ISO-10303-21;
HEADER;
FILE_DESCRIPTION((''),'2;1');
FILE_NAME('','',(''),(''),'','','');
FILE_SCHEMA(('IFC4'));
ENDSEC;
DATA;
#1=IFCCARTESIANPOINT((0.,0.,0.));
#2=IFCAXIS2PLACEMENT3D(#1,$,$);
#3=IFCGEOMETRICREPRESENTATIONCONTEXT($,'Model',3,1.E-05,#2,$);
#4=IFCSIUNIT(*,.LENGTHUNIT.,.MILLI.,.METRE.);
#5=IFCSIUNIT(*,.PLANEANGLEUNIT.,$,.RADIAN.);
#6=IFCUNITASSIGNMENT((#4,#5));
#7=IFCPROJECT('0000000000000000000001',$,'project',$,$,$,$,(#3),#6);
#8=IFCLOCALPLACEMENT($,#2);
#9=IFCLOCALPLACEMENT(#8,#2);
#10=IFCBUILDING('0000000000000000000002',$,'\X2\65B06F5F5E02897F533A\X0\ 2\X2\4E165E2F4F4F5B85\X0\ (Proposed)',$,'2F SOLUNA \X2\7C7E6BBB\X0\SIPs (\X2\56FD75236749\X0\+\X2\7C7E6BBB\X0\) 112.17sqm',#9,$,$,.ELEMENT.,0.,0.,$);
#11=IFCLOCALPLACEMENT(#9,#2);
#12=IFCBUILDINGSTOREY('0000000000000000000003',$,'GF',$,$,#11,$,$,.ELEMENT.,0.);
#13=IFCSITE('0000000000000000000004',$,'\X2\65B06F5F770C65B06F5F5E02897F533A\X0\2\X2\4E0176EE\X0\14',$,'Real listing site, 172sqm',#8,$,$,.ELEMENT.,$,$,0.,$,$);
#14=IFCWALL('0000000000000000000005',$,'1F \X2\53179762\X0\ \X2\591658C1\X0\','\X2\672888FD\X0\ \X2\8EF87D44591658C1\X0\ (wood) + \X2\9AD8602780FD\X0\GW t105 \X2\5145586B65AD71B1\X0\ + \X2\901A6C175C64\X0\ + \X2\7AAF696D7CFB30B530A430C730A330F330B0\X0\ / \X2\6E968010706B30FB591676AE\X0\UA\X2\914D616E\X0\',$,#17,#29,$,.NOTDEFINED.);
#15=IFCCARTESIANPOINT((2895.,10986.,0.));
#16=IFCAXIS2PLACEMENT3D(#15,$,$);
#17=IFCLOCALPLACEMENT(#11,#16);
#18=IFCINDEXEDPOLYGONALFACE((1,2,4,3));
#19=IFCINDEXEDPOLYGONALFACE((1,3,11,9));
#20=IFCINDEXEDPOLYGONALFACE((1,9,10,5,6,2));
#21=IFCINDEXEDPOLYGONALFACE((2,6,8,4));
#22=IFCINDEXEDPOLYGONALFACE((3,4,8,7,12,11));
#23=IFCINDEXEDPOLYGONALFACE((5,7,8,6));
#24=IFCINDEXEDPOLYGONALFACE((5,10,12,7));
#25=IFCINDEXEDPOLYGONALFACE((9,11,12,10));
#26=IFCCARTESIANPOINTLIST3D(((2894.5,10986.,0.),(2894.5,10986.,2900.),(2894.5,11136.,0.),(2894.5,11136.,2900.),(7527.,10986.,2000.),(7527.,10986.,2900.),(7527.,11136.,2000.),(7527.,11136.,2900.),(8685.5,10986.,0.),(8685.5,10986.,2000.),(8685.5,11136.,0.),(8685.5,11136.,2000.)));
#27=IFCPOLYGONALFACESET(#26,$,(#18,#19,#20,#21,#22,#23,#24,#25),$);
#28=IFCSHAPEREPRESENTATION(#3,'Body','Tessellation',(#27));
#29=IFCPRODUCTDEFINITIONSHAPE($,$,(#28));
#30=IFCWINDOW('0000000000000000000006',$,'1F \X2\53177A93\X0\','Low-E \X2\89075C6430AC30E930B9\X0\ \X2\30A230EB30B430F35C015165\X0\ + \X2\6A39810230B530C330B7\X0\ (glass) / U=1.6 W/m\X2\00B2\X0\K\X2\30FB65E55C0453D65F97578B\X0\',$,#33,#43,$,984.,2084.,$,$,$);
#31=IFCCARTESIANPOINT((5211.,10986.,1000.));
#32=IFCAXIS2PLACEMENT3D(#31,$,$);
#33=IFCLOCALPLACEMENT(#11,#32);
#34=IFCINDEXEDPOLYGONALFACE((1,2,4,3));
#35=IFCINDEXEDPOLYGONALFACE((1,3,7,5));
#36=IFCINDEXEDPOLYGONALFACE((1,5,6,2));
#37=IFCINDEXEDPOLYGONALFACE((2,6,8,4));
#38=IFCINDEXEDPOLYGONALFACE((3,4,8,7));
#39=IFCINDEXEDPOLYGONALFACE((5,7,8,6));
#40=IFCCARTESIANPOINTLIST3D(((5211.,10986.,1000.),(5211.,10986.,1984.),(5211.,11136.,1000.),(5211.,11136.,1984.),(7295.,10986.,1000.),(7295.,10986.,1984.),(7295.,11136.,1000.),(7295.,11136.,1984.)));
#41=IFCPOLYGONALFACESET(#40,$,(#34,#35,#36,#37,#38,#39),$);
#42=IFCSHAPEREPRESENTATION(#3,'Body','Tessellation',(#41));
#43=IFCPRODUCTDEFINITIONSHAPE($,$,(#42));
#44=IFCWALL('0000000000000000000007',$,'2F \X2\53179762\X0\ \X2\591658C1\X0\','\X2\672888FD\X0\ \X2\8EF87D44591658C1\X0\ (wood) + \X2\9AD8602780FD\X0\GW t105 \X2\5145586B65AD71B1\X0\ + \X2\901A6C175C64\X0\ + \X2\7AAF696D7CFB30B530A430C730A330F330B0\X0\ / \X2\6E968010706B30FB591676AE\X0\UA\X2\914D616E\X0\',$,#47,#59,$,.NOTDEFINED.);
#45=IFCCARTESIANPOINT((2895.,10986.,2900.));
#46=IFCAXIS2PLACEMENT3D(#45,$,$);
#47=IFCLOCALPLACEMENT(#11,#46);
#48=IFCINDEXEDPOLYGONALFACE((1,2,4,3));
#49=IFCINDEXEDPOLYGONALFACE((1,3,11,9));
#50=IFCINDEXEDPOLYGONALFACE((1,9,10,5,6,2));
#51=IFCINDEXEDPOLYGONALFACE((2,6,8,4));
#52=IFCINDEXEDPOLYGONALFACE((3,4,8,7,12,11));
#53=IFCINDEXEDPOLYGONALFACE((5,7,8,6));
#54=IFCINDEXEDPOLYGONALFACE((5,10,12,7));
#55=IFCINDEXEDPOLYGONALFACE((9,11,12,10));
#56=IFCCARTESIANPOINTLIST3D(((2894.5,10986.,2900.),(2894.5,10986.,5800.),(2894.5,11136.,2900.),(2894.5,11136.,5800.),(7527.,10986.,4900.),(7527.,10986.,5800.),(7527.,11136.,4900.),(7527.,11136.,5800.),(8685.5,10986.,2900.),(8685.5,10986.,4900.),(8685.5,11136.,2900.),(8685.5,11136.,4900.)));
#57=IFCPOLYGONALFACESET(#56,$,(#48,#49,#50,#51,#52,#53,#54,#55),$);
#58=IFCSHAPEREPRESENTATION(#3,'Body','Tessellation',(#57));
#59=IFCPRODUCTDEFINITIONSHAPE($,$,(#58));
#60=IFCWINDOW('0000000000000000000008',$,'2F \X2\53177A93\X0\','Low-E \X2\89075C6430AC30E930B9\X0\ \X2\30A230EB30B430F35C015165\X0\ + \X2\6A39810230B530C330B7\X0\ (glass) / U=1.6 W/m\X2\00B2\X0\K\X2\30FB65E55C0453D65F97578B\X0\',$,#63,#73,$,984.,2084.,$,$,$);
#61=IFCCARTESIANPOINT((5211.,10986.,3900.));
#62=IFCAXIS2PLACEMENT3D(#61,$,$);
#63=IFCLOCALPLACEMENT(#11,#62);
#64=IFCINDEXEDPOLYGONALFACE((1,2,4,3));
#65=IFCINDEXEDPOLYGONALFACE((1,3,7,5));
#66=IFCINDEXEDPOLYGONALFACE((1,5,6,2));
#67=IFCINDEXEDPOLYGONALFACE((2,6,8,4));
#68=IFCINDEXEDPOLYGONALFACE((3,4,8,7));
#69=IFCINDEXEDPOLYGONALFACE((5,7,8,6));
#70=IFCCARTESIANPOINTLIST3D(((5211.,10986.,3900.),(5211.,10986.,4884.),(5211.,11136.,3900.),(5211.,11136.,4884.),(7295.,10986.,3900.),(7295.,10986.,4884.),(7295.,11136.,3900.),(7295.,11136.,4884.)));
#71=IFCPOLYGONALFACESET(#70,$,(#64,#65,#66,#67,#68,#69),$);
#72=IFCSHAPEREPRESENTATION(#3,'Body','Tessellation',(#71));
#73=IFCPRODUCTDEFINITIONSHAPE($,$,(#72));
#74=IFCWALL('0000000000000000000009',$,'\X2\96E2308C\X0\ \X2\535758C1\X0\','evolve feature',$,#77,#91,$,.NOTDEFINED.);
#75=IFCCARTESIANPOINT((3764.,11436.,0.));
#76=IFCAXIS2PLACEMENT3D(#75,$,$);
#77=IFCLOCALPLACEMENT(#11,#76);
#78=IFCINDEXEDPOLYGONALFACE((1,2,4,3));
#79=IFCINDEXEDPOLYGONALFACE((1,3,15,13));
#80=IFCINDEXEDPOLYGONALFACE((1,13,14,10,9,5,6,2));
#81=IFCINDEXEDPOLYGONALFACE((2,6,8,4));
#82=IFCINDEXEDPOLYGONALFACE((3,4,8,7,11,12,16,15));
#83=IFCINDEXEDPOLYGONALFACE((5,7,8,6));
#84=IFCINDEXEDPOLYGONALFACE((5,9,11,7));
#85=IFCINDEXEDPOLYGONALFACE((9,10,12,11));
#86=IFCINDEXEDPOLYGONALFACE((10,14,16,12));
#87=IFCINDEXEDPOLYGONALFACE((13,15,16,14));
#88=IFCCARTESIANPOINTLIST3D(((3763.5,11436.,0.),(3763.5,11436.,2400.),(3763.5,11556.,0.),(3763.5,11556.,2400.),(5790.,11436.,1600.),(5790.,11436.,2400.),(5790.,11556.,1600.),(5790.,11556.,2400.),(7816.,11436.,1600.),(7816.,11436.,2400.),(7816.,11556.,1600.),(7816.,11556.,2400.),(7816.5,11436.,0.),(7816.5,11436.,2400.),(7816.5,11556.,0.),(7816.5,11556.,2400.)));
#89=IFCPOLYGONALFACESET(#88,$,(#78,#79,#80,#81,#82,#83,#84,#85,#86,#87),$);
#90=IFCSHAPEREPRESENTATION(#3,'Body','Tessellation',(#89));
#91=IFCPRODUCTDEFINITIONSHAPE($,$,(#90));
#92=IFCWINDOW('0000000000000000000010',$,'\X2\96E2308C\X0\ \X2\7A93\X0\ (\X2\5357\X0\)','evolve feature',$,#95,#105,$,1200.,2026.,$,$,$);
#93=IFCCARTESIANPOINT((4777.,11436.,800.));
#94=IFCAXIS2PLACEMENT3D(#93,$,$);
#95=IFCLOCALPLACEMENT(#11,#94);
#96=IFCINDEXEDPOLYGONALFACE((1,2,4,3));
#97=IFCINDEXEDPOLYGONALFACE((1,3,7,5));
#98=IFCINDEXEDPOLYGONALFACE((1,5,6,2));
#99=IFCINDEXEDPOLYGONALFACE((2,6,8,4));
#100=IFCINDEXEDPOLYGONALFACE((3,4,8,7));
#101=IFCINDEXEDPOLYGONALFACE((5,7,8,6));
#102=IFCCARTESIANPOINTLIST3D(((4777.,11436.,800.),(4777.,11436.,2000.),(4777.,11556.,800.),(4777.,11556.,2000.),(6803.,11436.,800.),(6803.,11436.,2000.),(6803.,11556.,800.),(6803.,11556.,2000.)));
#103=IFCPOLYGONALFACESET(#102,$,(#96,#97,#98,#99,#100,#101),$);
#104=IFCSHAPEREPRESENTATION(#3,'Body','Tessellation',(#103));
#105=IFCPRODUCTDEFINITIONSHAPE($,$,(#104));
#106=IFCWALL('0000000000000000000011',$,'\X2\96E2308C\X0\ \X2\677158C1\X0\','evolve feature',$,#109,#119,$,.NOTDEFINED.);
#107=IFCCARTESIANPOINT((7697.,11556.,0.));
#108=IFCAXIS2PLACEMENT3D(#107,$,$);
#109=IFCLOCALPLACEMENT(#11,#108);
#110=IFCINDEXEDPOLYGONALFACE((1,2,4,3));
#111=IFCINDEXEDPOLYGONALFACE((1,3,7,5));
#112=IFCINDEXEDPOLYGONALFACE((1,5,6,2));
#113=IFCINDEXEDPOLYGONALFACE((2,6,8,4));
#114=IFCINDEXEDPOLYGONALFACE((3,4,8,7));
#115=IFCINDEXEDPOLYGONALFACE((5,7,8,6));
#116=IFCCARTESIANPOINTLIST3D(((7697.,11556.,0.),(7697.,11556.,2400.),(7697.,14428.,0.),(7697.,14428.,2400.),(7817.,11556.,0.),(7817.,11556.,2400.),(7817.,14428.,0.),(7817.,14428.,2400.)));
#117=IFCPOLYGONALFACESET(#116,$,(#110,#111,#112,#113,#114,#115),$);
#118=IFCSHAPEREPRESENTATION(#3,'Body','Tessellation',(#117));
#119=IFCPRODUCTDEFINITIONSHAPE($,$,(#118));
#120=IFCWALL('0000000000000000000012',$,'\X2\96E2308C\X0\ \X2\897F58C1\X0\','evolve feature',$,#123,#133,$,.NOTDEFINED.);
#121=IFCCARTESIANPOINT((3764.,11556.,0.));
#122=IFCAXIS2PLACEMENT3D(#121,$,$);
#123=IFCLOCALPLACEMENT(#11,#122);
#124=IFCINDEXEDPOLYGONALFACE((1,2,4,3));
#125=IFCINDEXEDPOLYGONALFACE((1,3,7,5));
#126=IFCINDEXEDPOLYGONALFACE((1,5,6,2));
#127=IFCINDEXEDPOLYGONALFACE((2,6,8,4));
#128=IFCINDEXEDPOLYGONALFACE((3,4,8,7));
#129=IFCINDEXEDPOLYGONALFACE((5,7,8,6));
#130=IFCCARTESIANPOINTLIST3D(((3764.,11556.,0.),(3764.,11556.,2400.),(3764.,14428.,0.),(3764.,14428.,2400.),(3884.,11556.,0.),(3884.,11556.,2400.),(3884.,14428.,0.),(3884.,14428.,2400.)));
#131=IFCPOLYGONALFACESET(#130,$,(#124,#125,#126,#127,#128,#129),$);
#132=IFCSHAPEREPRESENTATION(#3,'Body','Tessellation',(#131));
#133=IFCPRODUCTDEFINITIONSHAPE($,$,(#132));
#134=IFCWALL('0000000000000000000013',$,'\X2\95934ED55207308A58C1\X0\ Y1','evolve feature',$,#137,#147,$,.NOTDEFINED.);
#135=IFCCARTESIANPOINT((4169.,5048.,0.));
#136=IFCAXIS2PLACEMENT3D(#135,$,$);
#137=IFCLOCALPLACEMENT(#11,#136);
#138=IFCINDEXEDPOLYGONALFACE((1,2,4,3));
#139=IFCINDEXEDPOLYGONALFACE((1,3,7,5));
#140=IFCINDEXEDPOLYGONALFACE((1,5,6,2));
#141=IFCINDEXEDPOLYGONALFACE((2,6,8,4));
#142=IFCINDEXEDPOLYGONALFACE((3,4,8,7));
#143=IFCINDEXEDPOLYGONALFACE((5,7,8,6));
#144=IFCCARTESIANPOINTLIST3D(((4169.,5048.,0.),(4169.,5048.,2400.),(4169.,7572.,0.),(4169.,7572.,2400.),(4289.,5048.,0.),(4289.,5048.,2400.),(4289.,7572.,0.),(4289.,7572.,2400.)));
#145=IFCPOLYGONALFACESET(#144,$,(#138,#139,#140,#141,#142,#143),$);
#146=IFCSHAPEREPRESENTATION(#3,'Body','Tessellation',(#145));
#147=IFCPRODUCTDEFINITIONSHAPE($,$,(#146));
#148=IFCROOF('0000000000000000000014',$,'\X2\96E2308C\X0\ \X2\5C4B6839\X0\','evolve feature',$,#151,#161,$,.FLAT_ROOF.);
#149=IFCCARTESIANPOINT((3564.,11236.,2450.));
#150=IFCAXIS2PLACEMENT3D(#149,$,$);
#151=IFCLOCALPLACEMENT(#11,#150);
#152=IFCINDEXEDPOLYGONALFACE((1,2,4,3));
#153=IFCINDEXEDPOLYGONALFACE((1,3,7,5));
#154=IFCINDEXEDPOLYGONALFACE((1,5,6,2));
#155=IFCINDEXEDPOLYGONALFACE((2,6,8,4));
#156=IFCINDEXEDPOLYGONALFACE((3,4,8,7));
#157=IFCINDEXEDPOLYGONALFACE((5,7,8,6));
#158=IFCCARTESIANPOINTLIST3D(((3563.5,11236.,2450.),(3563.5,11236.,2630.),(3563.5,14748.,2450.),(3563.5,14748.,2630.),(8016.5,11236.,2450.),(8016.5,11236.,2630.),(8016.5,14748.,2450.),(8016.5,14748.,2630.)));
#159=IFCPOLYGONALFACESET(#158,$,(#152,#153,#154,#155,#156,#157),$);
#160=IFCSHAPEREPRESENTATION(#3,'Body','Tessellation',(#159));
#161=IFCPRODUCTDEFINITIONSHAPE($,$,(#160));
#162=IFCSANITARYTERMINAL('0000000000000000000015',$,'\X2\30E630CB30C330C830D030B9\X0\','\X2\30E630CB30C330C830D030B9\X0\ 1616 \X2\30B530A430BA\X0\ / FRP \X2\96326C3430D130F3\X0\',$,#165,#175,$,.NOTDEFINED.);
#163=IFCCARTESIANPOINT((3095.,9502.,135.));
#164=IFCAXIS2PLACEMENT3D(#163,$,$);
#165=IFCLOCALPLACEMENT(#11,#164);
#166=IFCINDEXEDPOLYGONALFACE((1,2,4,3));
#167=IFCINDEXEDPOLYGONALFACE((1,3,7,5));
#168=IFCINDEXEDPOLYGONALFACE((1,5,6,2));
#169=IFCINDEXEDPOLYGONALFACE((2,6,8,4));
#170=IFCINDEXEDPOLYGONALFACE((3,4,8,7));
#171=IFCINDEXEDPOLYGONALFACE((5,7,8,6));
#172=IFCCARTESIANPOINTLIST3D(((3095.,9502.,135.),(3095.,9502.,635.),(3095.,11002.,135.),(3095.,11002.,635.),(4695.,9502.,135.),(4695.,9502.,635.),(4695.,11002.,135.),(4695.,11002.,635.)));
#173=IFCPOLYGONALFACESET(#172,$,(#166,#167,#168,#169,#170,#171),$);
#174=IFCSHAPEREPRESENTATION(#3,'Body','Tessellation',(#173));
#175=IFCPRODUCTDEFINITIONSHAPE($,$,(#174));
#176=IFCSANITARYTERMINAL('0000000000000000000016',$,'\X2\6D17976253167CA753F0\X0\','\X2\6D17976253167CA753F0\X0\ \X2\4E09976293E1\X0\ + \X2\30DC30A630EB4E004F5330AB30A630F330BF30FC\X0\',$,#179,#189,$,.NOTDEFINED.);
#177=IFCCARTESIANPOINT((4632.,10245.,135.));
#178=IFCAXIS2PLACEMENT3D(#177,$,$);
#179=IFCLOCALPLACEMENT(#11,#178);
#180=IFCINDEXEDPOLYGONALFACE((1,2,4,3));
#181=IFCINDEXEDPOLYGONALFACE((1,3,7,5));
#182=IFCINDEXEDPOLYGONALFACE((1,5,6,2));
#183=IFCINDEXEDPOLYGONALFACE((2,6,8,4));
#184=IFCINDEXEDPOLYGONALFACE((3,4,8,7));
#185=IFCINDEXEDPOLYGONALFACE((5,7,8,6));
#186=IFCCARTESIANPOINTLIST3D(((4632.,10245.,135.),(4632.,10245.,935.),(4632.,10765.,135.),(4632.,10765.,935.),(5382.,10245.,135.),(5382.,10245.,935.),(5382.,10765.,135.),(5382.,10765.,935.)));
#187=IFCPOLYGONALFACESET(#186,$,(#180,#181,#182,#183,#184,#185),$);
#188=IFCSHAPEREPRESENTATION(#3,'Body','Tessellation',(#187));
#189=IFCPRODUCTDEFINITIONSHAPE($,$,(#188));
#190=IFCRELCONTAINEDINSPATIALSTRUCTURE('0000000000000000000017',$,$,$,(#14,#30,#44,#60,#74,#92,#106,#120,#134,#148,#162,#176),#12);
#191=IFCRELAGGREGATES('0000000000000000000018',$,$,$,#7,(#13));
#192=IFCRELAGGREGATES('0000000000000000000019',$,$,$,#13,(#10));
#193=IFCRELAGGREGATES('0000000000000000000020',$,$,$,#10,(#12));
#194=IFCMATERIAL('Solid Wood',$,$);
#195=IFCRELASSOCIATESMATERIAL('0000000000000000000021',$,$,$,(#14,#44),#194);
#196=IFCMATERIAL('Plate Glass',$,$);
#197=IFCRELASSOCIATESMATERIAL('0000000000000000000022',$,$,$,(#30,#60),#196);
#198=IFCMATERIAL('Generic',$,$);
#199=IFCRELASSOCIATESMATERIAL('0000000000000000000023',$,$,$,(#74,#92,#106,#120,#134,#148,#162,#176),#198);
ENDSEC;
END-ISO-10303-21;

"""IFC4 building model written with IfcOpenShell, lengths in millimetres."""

from ifc_helpers import new_model, si_unit, frame, frame_2d, origin, place, context, project, spatial, rectangle, extrude, material, element, fill, save


model = new_model("IFC4")

# Units and contexts
model_context = context("Model", 3, precision=1e-05, world=origin())
ifc_project = project(units=[si_unit("LENGTHUNIT", "METRE", prefix="MILLI"), si_unit("PLANEANGLEUNIT", "RADIAN")], contexts=[model_context])

# Site, building, storey
site_placement = place(None, origin())
site = spatial("IfcSite", under=ifc_project, at=site_placement, Name="新潟県新潟市西区2丁目14", ObjectType="Real listing site, 172sqm", CompositionType="ELEMENT", RefElevation=0.0)
building_placement = place(site_placement, origin())
building = spatial("IfcBuilding", under=site, at=building_placement, Name="新潟市西区 2世帯住宅 (Proposed)", ObjectType="2F SOLUNA 籾殻SIPs (国産杉+籾殻) 112.17sqm", CompositionType="ELEMENT", ElevationOfRefHeight=0.0, ElevationOfTerrain=0.0)
storey_placement = place(building_placement, origin())
storey = spatial("IfcBuildingStorey", under=building, at=storey_placement, Name="GF", CompositionType="ELEMENT", Elevation=0.0)

# Shared definitions
ifc_material_1 = material(Name="Generic")

# Wall, opening, window
ifc_material_2 = material(Name="Solid Wood")
wall_1_placement = place(storey_placement, frame((2895.0, 10986.0, 0.0)))
wall_1 = element("IfcWall", 1, at=wall_1_placement, inside=storey, material=ifc_material_2, Name="1F 北面 外壁", Description="木製 軸組外壁 (wood) + 高性能GW t105 充填断熱 + 通気層 + 窯業系サイディング / 準耐火・外皮UA配慮", PredefinedType="NOTDEFINED", context=model_context, shape_type="SweptSolid", body=[
    extrude(rectangle(XDim=5791.0, YDim=150.0, at=frame_2d((2895.0, 75.0))), frame((2895.0, 10986.0, 0.0)), (0.0, 0.0, 1.0), 2900.0),
])
opening_1_placement = place(storey_placement, frame((5211.0, 10986.0, 1000.0)))
opening_1 = element("IfcOpeningElement", 2, at=opening_1_placement, cuts=wall_1, PredefinedType="NOTDEFINED", context=model_context, shape_type="SweptSolid", body=[
    extrude(rectangle(XDim=2084.0, YDim=150.0, at=frame_2d((1042.0, 75.0))), frame((5211.0, 10986.0, 1000.0)), (0.0, 0.0, 1.0), 984.0),
])
ifc_material_3 = material(Name="Plate Glass")
window_1_placement = place(storey_placement, frame((5211.0, 10986.0, 1000.0)))
window_1 = element("IfcWindow", 3, at=window_1_placement, inside=storey, material=ifc_material_3, Name="1F 北窓", Description="Low-E 複層ガラス アルゴン封入 + 樹脂サッシ (glass) / U=1.6 W/m²K・日射取得型", OverallHeight=984.0, OverallWidth=2084.0, context=model_context, shape_type="SweptSolid", body=[
    extrude(rectangle(XDim=2084.0, YDim=150.0, at=frame_2d((1042.0, 75.0))), frame((5211.0, 10986.0, 1000.0)), (0.0, 0.0, 1.0), 984.0),
])
fill(opening_1, window_1)

# Wall, opening, window
wall_2_placement = place(storey_placement, frame((2895.0, 10986.0, 2900.0)))
wall_2 = element("IfcWall", 4, at=wall_2_placement, inside=storey, material=ifc_material_2, Name="2F 北面 外壁", Description="木製 軸組外壁 (wood) + 高性能GW t105 充填断熱 + 通気層 + 窯業系サイディング / 準耐火・外皮UA配慮", PredefinedType="NOTDEFINED", context=model_context, shape_type="SweptSolid", body=[
    extrude(rectangle(XDim=5791.0, YDim=150.0, at=frame_2d((2895.0, 75.0))), frame((2895.0, 10986.0, 2900.0)), (0.0, 0.0, 1.0), 2900.0),
])
opening_2_placement = place(storey_placement, frame((5211.0, 10986.0, 3900.0)))
opening_2 = element("IfcOpeningElement", 5, at=opening_2_placement, cuts=wall_2, PredefinedType="NOTDEFINED", context=model_context, shape_type="SweptSolid", body=[
    extrude(rectangle(XDim=2084.0, YDim=150.0, at=frame_2d((1042.0, 75.0))), frame((5211.0, 10986.0, 3900.0)), (0.0, 0.0, 1.0), 984.0),
])
window_2_placement = place(storey_placement, frame((5211.0, 10986.0, 3900.0)))
window_2 = element("IfcWindow", 6, at=window_2_placement, inside=storey, material=ifc_material_3, Name="2F 北窓", Description="Low-E 複層ガラス アルゴン封入 + 樹脂サッシ (glass) / U=1.6 W/m²K・日射取得型", OverallHeight=984.0, OverallWidth=2084.0, context=model_context, shape_type="SweptSolid", body=[
    extrude(rectangle(XDim=2084.0, YDim=150.0, at=frame_2d((1042.0, 75.0))), frame((5211.0, 10986.0, 3900.0)), (0.0, 0.0, 1.0), 984.0),
])
fill(opening_2, window_2)

# Wall, opening, window
wall_3_placement = place(storey_placement, frame((3764.0, 11436.0, 0.0)))
wall_3 = element("IfcWall", 7, at=wall_3_placement, inside=storey, material=ifc_material_1, Name="離れ 南壁", Description="evolve feature", PredefinedType="NOTDEFINED", context=model_context, shape_type="SweptSolid", body=[
    extrude(rectangle(XDim=4053.0, YDim=120.0, at=frame_2d((2026.0, 60.0))), frame((3764.0, 11436.0, 0.0)), (0.0, 0.0, 1.0), 2400.0),
])
opening_3_placement = place(storey_placement, frame((4777.0, 11436.0, 800.0)))
opening_3 = element("IfcOpeningElement", 8, at=opening_3_placement, cuts=wall_3, PredefinedType="NOTDEFINED", context=model_context, shape_type="SweptSolid", body=[
    extrude(rectangle(XDim=2026.0, YDim=120.0, at=frame_2d((1013.0, 60.0))), frame((4777.0, 11436.0, 800.0)), (0.0, 0.0, 1.0), 1200.0),
])
window_3_placement = place(storey_placement, frame((4777.0, 11436.0, 800.0)))
window_3 = element("IfcWindow", 9, at=window_3_placement, inside=storey, material=ifc_material_1, Name="離れ 窓 (南)", Description="evolve feature", OverallHeight=1200.0, OverallWidth=2026.0, context=model_context, shape_type="SweptSolid", body=[
    extrude(rectangle(XDim=2026.0, YDim=120.0, at=frame_2d((1013.0, 60.0))), frame((4777.0, 11436.0, 800.0)), (0.0, 0.0, 1.0), 1200.0),
])
fill(opening_3, window_3)

# Walls
wall_4_placement = place(storey_placement, frame((7697.0, 11556.0, 0.0)))
element("IfcWall", 10, at=wall_4_placement, inside=storey, material=ifc_material_1, Name="離れ 東壁", Description="evolve feature", PredefinedType="NOTDEFINED", context=model_context, shape_type="SweptSolid", body=[
    extrude(rectangle(XDim=120.0, YDim=2872.0, at=frame_2d((60.0, 1436.0))), frame((7697.0, 11556.0, 0.0)), (0.0, 0.0, 1.0), 2400.0),
])
wall_5_placement = place(storey_placement, frame((3764.0, 11556.0, 0.0)))
element("IfcWall", 11, at=wall_5_placement, inside=storey, material=ifc_material_1, Name="離れ 西壁", Description="evolve feature", PredefinedType="NOTDEFINED", context=model_context, shape_type="SweptSolid", body=[
    extrude(rectangle(XDim=120.0, YDim=2872.0, at=frame_2d((60.0, 1436.0))), frame((3764.0, 11556.0, 0.0)), (0.0, 0.0, 1.0), 2400.0),
])
wall_6_placement = place(storey_placement, frame((4169.0, 5048.0, 0.0)))
element("IfcWall", 12, at=wall_6_placement, inside=storey, material=ifc_material_1, Name="間仕切り壁 Y1", Description="evolve feature", PredefinedType="NOTDEFINED", context=model_context, shape_type="SweptSolid", body=[
    extrude(rectangle(XDim=120.0, YDim=2524.0, at=frame_2d((60.0, 1262.0))), frame((4169.0, 5048.0, 0.0)), (0.0, 0.0, 1.0), 2400.0),
])

# Roof
roof_1_placement = place(storey_placement, frame((3564.0, 11236.0, 2450.0)))
element("IfcRoof", 13, at=roof_1_placement, inside=storey, material=ifc_material_1, Name="離れ 屋根", Description="evolve feature", PredefinedType="FLAT_ROOF", context=model_context, shape_type="SweptSolid", body=[
    extrude(rectangle(XDim=4453.0, YDim=3512.0, at=frame_2d((2226.0, 1756.0))), frame((3564.0, 11236.0, 2450.0)), (0.0, 0.0, 1.0), 180.0),
])

# Sanitary terminals
sanitary_terminal_1_placement = place(storey_placement, frame((3095.0, 9502.0, 135.0)))
element("IfcSanitaryTerminal", 14, at=sanitary_terminal_1_placement, inside=storey, material=ifc_material_1, Name="ユニットバス", Description="ユニットバス 1616 サイズ / FRP 防水パン", PredefinedType="NOTDEFINED", context=model_context, shape_type="SweptSolid", body=[
    extrude(rectangle(XDim=1600.0, YDim=1500.0, at=frame_2d((800.0, 750.0))), frame((3095.0, 9502.0, 135.0)), (0.0, 0.0, 1.0), 500.0),
])
sanitary_terminal_2_placement = place(storey_placement, frame((4632.0, 10245.0, 135.0)))
element("IfcSanitaryTerminal", 15, at=sanitary_terminal_2_placement, inside=storey, material=ifc_material_1, Name="洗面化粧台", Description="洗面化粧台 三面鏡 + ボウル一体カウンター", PredefinedType="NOTDEFINED", context=model_context, shape_type="SweptSolid", body=[
    extrude(rectangle(XDim=750.0, YDim=520.0, at=frame_2d((375.0, 260.0))), frame((4632.0, 10245.0, 135.0)), (0.0, 0.0, 1.0), 800.0),
])

save(model, "model.ifc")
